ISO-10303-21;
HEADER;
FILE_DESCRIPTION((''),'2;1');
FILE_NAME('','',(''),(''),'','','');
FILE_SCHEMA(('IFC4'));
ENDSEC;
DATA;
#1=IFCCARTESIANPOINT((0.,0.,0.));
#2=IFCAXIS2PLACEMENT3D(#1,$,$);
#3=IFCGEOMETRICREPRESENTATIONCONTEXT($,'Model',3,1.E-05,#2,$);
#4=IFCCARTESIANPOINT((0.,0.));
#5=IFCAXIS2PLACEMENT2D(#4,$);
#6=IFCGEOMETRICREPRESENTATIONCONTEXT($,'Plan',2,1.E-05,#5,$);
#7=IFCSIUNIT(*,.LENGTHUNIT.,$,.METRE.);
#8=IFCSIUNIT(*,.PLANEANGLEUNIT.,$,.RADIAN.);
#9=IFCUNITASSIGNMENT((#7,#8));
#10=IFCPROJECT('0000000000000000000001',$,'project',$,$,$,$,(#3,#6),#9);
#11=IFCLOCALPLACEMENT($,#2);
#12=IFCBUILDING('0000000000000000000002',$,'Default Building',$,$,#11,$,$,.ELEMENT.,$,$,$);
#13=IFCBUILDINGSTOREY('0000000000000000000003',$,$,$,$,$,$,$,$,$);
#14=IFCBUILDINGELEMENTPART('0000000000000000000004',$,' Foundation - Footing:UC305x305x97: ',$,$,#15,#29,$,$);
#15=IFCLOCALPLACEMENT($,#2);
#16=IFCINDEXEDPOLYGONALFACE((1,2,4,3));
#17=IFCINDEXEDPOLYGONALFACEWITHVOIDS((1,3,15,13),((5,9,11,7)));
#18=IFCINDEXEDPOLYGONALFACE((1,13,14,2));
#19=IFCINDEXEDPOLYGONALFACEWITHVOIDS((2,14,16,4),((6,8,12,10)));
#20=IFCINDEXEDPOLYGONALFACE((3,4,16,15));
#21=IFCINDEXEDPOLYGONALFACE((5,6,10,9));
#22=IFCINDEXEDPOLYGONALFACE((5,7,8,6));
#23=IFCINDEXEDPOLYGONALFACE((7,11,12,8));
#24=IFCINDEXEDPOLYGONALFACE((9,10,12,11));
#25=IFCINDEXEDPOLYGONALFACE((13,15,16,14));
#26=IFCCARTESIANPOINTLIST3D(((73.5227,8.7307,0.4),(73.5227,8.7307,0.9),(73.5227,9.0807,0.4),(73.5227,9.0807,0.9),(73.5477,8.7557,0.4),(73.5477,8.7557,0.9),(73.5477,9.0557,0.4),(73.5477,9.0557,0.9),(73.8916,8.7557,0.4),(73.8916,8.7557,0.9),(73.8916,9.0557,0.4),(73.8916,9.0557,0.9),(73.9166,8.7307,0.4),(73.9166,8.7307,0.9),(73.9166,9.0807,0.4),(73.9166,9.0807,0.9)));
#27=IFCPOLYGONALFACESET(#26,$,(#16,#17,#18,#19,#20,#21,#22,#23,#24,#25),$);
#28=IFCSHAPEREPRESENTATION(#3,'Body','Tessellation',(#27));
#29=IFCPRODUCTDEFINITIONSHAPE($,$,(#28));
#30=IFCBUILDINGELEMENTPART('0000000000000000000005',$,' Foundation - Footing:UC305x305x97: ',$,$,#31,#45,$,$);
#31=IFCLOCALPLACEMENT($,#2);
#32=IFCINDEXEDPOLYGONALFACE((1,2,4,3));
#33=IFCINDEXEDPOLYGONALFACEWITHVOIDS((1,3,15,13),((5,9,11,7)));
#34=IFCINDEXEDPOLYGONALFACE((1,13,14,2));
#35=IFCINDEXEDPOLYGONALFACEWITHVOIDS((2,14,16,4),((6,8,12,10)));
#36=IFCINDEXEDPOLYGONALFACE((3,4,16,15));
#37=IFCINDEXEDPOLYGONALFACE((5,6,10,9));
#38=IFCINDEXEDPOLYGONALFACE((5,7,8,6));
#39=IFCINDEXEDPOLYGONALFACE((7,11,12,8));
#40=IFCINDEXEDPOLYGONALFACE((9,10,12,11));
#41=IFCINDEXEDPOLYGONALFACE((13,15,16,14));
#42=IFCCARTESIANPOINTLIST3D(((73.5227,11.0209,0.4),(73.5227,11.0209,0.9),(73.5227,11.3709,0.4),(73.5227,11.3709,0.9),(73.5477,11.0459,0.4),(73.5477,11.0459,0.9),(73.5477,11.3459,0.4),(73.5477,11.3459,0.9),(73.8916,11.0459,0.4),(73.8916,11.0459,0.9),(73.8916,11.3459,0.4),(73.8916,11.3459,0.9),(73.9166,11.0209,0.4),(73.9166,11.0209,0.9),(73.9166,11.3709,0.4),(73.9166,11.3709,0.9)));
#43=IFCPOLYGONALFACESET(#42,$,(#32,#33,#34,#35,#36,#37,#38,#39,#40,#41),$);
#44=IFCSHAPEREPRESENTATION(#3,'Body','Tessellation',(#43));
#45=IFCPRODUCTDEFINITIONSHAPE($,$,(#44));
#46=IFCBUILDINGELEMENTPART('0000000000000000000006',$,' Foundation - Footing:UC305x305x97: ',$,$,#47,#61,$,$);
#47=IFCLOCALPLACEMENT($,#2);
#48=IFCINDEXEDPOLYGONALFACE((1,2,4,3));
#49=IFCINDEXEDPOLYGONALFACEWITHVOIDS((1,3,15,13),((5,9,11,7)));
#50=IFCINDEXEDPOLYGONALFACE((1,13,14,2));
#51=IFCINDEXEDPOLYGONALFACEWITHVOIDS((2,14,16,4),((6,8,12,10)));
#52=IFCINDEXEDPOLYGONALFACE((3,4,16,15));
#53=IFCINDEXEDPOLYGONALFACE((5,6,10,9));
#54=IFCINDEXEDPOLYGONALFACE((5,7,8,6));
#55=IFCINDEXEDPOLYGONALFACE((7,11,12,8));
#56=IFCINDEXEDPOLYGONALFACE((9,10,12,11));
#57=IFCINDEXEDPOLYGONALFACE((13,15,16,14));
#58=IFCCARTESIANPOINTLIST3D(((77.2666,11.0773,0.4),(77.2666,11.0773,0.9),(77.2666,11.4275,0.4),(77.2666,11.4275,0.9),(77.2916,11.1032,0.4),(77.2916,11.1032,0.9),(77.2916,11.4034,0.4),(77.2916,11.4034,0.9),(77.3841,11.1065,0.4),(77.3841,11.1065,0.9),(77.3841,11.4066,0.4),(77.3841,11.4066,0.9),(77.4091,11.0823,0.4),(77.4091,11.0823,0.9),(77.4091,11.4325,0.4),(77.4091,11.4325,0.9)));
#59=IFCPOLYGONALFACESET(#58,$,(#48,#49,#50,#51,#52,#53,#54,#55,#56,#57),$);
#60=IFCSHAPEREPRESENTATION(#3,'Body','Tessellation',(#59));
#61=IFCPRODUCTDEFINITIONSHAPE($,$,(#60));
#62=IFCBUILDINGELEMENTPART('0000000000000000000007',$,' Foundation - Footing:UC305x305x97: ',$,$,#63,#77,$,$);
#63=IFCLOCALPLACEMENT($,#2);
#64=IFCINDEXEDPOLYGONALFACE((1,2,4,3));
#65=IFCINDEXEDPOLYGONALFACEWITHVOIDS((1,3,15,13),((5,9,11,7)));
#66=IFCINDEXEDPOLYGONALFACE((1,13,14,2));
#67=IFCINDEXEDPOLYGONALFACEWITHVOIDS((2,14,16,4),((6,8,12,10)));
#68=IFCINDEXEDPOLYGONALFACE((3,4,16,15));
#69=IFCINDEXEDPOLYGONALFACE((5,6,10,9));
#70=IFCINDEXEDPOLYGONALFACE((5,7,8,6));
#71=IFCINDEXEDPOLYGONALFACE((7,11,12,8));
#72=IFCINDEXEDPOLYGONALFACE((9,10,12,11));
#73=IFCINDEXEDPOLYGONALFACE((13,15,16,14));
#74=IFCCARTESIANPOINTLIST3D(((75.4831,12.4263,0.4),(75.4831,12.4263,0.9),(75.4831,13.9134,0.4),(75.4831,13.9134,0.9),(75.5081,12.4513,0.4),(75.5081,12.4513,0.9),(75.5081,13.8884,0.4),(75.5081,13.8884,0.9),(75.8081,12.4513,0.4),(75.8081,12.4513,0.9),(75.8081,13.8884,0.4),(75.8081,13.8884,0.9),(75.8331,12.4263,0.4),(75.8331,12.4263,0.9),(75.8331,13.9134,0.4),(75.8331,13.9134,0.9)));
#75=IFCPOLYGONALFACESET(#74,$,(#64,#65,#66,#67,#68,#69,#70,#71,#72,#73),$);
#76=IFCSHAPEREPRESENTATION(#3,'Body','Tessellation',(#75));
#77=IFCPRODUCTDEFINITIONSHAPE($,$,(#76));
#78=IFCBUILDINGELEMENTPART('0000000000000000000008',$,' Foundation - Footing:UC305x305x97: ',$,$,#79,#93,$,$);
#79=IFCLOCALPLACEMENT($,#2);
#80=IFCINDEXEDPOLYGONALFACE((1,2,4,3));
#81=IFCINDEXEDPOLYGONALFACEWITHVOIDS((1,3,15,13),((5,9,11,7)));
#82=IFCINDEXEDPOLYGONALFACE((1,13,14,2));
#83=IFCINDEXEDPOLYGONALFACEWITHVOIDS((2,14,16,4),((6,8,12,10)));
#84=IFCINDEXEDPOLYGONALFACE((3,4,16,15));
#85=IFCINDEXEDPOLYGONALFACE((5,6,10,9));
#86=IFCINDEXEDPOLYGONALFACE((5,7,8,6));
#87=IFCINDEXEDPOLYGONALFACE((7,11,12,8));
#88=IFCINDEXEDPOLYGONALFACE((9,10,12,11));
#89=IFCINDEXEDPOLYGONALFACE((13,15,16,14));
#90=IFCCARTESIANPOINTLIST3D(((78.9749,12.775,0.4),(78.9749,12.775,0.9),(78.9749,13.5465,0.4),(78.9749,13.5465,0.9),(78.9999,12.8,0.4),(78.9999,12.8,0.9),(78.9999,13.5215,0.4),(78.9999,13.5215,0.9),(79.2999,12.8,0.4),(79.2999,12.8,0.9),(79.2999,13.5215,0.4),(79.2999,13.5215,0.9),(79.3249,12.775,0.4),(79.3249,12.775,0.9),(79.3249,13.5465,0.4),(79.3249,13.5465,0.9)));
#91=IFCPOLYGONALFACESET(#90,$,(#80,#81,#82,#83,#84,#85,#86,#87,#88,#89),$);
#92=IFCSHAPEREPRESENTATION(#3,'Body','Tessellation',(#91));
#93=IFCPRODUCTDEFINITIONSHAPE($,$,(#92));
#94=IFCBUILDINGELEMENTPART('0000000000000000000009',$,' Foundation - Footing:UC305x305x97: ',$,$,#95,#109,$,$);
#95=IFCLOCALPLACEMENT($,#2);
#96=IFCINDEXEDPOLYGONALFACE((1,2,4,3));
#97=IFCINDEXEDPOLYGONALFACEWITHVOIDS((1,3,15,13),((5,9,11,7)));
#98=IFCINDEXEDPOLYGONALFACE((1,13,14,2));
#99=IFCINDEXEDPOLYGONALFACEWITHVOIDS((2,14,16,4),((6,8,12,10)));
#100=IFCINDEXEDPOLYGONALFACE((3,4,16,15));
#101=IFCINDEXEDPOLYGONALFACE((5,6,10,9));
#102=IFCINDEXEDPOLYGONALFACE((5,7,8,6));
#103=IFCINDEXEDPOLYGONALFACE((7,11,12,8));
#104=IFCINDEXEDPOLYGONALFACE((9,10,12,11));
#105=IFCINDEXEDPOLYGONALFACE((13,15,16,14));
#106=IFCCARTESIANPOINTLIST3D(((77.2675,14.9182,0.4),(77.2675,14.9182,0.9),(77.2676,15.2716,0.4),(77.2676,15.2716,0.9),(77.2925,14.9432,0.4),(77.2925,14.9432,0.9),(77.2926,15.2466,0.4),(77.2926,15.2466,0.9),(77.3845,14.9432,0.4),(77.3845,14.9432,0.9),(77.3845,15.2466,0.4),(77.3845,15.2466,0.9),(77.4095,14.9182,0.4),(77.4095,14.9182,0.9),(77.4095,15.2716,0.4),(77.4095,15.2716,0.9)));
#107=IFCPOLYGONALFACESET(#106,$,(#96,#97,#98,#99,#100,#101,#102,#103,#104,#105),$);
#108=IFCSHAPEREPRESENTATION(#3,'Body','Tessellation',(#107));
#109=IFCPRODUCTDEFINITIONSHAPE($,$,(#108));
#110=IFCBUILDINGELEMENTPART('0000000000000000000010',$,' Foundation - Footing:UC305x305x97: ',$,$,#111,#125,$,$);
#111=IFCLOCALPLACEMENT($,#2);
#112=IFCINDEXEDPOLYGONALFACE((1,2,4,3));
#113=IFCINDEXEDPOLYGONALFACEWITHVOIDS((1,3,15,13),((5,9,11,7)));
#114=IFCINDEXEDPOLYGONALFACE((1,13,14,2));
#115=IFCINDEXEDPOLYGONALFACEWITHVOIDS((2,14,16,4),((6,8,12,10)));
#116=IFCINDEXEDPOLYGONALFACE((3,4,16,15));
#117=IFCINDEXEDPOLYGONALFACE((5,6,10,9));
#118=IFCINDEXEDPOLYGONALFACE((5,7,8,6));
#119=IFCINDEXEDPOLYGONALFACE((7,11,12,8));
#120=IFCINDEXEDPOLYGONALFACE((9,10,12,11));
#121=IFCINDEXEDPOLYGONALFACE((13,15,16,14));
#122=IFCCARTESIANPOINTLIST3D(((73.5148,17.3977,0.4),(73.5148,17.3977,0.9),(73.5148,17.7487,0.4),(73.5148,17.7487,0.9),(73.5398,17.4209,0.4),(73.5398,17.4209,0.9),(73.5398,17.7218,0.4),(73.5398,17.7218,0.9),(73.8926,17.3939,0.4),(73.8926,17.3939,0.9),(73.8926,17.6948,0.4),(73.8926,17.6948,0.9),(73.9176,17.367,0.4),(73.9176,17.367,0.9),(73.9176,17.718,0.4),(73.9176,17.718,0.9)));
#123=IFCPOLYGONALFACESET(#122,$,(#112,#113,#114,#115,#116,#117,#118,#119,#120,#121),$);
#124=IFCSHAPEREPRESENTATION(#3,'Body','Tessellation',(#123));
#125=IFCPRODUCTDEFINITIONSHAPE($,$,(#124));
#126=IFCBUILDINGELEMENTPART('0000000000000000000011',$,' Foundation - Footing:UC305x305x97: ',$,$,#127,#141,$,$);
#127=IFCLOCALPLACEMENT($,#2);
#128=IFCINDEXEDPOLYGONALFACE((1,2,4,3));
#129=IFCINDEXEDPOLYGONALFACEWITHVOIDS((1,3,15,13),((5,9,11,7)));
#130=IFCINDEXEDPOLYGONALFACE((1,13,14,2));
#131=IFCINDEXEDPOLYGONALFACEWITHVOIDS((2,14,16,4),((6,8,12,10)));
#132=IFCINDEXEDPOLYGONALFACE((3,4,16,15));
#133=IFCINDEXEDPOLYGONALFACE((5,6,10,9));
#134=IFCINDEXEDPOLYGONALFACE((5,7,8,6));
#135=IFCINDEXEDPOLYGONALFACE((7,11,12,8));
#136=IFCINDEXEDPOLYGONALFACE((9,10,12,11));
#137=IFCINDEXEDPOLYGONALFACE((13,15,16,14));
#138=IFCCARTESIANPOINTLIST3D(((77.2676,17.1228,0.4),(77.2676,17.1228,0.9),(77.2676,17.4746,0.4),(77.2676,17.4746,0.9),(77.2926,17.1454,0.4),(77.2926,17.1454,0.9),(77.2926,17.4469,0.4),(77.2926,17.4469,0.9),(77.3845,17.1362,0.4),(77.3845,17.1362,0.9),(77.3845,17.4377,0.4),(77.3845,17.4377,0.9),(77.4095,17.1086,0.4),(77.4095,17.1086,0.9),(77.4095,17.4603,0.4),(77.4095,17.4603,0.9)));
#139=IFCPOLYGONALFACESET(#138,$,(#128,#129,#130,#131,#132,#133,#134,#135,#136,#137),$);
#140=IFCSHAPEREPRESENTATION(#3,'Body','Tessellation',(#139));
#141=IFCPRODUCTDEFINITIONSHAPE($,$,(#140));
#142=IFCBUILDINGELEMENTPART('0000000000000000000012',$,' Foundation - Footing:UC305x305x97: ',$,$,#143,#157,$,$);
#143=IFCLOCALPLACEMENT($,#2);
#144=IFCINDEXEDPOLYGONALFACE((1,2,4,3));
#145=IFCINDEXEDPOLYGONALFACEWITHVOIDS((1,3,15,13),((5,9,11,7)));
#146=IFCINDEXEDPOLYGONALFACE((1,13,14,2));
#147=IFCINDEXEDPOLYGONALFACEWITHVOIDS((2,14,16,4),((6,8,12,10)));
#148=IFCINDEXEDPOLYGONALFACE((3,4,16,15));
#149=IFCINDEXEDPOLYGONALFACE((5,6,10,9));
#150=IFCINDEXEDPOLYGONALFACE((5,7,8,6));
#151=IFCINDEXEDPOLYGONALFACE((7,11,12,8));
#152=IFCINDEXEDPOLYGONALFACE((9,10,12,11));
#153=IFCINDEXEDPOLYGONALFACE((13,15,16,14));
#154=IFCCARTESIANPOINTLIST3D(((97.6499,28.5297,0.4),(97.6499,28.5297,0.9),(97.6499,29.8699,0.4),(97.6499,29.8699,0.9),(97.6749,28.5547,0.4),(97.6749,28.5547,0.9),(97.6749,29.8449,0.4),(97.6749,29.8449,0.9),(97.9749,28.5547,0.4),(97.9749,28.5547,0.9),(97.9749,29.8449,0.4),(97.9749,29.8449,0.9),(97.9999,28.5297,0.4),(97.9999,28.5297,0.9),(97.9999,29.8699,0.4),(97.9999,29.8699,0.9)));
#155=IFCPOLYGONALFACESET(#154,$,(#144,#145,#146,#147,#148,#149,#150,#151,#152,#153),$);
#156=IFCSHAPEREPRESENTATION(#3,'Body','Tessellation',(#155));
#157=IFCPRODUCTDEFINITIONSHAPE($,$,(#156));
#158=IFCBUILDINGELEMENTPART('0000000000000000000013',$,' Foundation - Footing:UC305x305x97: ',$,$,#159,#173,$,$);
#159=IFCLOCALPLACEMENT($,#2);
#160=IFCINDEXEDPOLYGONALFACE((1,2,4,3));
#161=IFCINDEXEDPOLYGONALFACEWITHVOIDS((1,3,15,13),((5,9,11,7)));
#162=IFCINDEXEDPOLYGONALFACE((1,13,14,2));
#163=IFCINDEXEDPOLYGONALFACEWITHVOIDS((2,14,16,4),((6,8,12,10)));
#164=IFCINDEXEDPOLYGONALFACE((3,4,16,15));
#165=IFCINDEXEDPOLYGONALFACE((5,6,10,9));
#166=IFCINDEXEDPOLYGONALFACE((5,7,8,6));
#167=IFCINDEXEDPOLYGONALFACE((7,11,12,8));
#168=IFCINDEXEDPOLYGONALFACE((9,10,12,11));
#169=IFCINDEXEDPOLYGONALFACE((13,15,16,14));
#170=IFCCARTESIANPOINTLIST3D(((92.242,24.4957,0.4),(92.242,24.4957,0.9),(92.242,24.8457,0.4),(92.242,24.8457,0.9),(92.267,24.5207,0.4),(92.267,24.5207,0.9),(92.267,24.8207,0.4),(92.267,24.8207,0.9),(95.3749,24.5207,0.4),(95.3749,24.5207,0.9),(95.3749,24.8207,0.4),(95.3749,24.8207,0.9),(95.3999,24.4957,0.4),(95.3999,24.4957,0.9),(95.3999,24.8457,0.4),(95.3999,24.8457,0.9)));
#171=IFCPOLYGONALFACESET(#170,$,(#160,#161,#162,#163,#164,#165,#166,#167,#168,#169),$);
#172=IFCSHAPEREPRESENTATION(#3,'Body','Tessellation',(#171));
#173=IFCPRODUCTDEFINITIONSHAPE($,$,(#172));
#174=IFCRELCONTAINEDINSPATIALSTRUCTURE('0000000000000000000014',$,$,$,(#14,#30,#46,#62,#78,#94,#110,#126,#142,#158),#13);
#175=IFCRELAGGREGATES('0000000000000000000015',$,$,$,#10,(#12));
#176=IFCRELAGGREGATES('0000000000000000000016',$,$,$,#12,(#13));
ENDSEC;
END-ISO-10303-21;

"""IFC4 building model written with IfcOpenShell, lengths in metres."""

from ifc_helpers import new_model, si_unit, origin, origin_2d, place, context, project, spatial, polyline, outline, extrude, element, save


model = new_model("IFC4")

# Units and contexts
model_context = context("Model", 3, precision=1e-05, world=origin())
plan_context = context("Plan", 2, precision=1e-05, world=origin_2d())
ifc_project = project(units=[si_unit("LENGTHUNIT", "METRE"), si_unit("PLANEANGLEUNIT", "RADIAN")], contexts=[model_context, plan_context])

# Building, storey
building_placement = place(None, origin())
building = spatial("IfcBuilding", under=ifc_project, at=building_placement, Name="Default Building", CompositionType="ELEMENT")
storey = spatial("IfcBuildingStorey", under=building)

# Building element parts, openings
building_element_part_1 = element("IfcBuildingElementPart", 1, inside=storey, Name=" Foundation - Footing:UC305x305x97: ", context=model_context, shape_type="SweptSolid", body=[
    extrude(outline(polyline([(73.9166, 8.7307, 0.4), (73.5227, 8.7307, 0.4), (73.5227, 9.0807, 0.4), (73.9166, 9.0807, 0.4), (73.9166, 8.7307, 0.4)])), None, (0.0, 0.0, 1.0), 0.5),
])
element("IfcOpeningElement", 2, inside=storey, cuts=building_element_part_1, context=model_context, shape_type="SweptSolid", body=[
    extrude(outline(polyline([(73.8916, 8.7557, 0.4), (73.5477, 8.7557, 0.4), (73.5477, 9.0557, 0.4), (73.8916, 9.0557, 0.4), (73.8916, 8.7557, 0.4)])), None, (0.0, 0.0, 1.0), 0.5),
])
building_element_part_2 = element("IfcBuildingElementPart", 3, inside=storey, Name=" Foundation - Footing:UC305x305x97: ", context=model_context, shape_type="SweptSolid", body=[
    extrude(outline(polyline([(73.9166, 11.0209, 0.4), (73.5227, 11.0209, 0.4), (73.5227, 11.3709, 0.4), (73.9166, 11.3709, 0.4), (73.9166, 11.0209, 0.4)])), None, (0.0, 0.0, 1.0), 0.5),
])
element("IfcOpeningElement", 4, inside=storey, cuts=building_element_part_2, context=model_context, shape_type="SweptSolid", body=[
    extrude(outline(polyline([(73.8916, 11.0459, 0.4), (73.5477, 11.0459, 0.4), (73.5477, 11.3459, 0.4), (73.8916, 11.3459, 0.4), (73.8916, 11.0459, 0.4)])), None, (0.0, 0.0, 1.0), 0.5),
])
building_element_part_3 = element("IfcBuildingElementPart", 5, inside=storey, Name=" Foundation - Footing:UC305x305x97: ", context=model_context, shape_type="SweptSolid", body=[
    extrude(outline(polyline([(77.4091, 11.0823, 0.4), (77.2666, 11.0773, 0.4), (77.2666, 11.4275, 0.4), (77.4091, 11.4325, 0.4), (77.4091, 11.0823, 0.4)])), None, (0.0, 0.0, 1.0), 0.5),
])
element("IfcOpeningElement", 6, inside=storey, cuts=building_element_part_3, context=model_context, shape_type="SweptSolid", body=[
    extrude(outline(polyline([(77.3841, 11.1065, 0.4), (77.2916, 11.1032, 0.4), (77.2916, 11.4034, 0.4), (77.3841, 11.4066, 0.4), (77.3841, 11.1065, 0.4)])), None, (0.0, 0.0, 1.0), 0.5),
])
building_element_part_4 = element("IfcBuildingElementPart", 7, inside=storey, Name=" Foundation - Footing:UC305x305x97: ", context=model_context, shape_type="SweptSolid", body=[
    extrude(outline(polyline([(75.8331, 12.4263, 0.4), (75.4831, 12.4263, 0.4), (75.4831, 13.9134, 0.4), (75.8331, 13.9134, 0.4), (75.8331, 12.4263, 0.4)])), None, (0.0, 0.0, 1.0), 0.5),
])
element("IfcOpeningElement", 8, inside=storey, cuts=building_element_part_4, context=model_context, shape_type="SweptSolid", body=[
    extrude(outline(polyline([(75.8081, 12.4513, 0.4), (75.5081, 12.4513, 0.4), (75.5081, 13.8884, 0.4), (75.8081, 13.8884, 0.4), (75.8081, 12.4513, 0.4)])), None, (0.0, 0.0, 1.0), 0.5),
])
building_element_part_5 = element("IfcBuildingElementPart", 9, inside=storey, Name=" Foundation - Footing:UC305x305x97: ", context=model_context, shape_type="SweptSolid", body=[
    extrude(outline(polyline([(79.3249, 12.775, 0.4), (78.9749, 12.775, 0.4), (78.9749, 13.5465, 0.4), (79.3249, 13.5465, 0.4), (79.3249, 12.775, 0.4)])), None, (0.0, 0.0, 1.0), 0.5),
])
element("IfcOpeningElement", 10, inside=storey, cuts=building_element_part_5, context=model_context, shape_type="SweptSolid", body=[
    extrude(outline(polyline([(79.2999, 12.8, 0.4), (78.9999, 12.8, 0.4), (78.9999, 13.5215, 0.4), (79.2999, 13.5215, 0.4), (79.2999, 12.8, 0.4)])), None, (0.0, 0.0, 1.0), 0.5),
])
building_element_part_6 = element("IfcBuildingElementPart", 11, inside=storey, Name=" Foundation - Footing:UC305x305x97: ", context=model_context, shape_type="SweptSolid", body=[
    extrude(outline(polyline([(77.4095, 14.9182, 0.4), (77.2675, 14.9182, 0.4), (77.2676, 15.2716, 0.4), (77.4095, 15.2716, 0.4), (77.4095, 14.9182, 0.4)])), None, (0.0, 0.0, 1.0), 0.5),
])
element("IfcOpeningElement", 12, inside=storey, cuts=building_element_part_6, context=model_context, shape_type="SweptSolid", body=[
    extrude(outline(polyline([(77.3845, 14.9432, 0.4), (77.2925, 14.9432, 0.4), (77.2926, 15.2466, 0.4), (77.3845, 15.2466, 0.4), (77.3845, 14.9432, 0.4)])), None, (0.0, 0.0, 1.0), 0.5),
])
building_element_part_7 = element("IfcBuildingElementPart", 13, inside=storey, Name=" Foundation - Footing:UC305x305x97: ", context=model_context, shape_type="SweptSolid", body=[
    extrude(outline(polyline([(73.9176, 17.367, 0.4), (73.5148, 17.3977, 0.4), (73.5148, 17.7487, 0.4), (73.9176, 17.718, 0.4), (73.9176, 17.367, 0.4)])), None, (0.0, 0.0, 1.0), 0.5),
])
element("IfcOpeningElement", 14, inside=storey, cuts=building_element_part_7, context=model_context, shape_type="SweptSolid", body=[
    extrude(outline(polyline([(73.8926, 17.3939, 0.4), (73.5398, 17.4209, 0.4), (73.5398, 17.7218, 0.4), (73.8926, 17.6948, 0.4), (73.8926, 17.3939, 0.4)])), None, (0.0, 0.0, 1.0), 0.5),
])
building_element_part_8 = element("IfcBuildingElementPart", 15, inside=storey, Name=" Foundation - Footing:UC305x305x97: ", context=model_context, shape_type="SweptSolid", body=[
    extrude(outline(polyline([(77.4095, 17.1086, 0.4), (77.2676, 17.1228, 0.4), (77.2676, 17.4746, 0.4), (77.4095, 17.4603, 0.4), (77.4095, 17.1086, 0.4)])), None, (0.0, 0.0, 1.0), 0.5),
])
element("IfcOpeningElement", 16, inside=storey, cuts=building_element_part_8, context=model_context, shape_type="SweptSolid", body=[
    extrude(outline(polyline([(77.3845, 17.1362, 0.4), (77.2926, 17.1454, 0.4), (77.2926, 17.4469, 0.4), (77.3845, 17.4377, 0.4), (77.3845, 17.1362, 0.4)])), None, (0.0, 0.0, 1.0), 0.5),
])
building_element_part_9 = element("IfcBuildingElementPart", 17, inside=storey, Name=" Foundation - Footing:UC305x305x97: ", context=model_context, shape_type="SweptSolid", body=[
    extrude(outline(polyline([(97.9999, 28.5297, 0.4), (97.6499, 28.5297, 0.4), (97.6499, 29.8699, 0.4), (97.9999, 29.8699, 0.4), (97.9999, 28.5297, 0.4)])), None, (0.0, 0.0, 1.0), 0.5),
])
element("IfcOpeningElement", 18, inside=storey, cuts=building_element_part_9, context=model_context, shape_type="SweptSolid", body=[
    extrude(outline(polyline([(97.9749, 28.5547, 0.4), (97.6749, 28.5547, 0.4), (97.6749, 29.8449, 0.4), (97.9749, 29.8449, 0.4), (97.9749, 28.5547, 0.4)])), None, (0.0, 0.0, 1.0), 0.5),
])
building_element_part_10 = element("IfcBuildingElementPart", 19, inside=storey, Name=" Foundation - Footing:UC305x305x97: ", context=model_context, shape_type="SweptSolid", body=[
    extrude(outline(polyline([(95.3999, 24.4957, 0.4), (95.3999, 24.8457, 0.4), (92.242, 24.8457, 0.4), (92.242, 24.4957, 0.4), (95.3999, 24.4957, 0.4)])), None, (0.0, 0.0, 1.0), 0.5),
])
element("IfcOpeningElement", 20, inside=storey, cuts=building_element_part_10, context=model_context, shape_type="SweptSolid", body=[
    extrude(outline(polyline([(95.3749, 24.5207, 0.4), (95.3749, 24.8207, 0.4), (92.267, 24.8207, 0.4), (92.267, 24.5207, 0.4), (95.3749, 24.5207, 0.4)])), None, (0.0, 0.0, 1.0), 0.5),
])

save(model, "model.ifc")
